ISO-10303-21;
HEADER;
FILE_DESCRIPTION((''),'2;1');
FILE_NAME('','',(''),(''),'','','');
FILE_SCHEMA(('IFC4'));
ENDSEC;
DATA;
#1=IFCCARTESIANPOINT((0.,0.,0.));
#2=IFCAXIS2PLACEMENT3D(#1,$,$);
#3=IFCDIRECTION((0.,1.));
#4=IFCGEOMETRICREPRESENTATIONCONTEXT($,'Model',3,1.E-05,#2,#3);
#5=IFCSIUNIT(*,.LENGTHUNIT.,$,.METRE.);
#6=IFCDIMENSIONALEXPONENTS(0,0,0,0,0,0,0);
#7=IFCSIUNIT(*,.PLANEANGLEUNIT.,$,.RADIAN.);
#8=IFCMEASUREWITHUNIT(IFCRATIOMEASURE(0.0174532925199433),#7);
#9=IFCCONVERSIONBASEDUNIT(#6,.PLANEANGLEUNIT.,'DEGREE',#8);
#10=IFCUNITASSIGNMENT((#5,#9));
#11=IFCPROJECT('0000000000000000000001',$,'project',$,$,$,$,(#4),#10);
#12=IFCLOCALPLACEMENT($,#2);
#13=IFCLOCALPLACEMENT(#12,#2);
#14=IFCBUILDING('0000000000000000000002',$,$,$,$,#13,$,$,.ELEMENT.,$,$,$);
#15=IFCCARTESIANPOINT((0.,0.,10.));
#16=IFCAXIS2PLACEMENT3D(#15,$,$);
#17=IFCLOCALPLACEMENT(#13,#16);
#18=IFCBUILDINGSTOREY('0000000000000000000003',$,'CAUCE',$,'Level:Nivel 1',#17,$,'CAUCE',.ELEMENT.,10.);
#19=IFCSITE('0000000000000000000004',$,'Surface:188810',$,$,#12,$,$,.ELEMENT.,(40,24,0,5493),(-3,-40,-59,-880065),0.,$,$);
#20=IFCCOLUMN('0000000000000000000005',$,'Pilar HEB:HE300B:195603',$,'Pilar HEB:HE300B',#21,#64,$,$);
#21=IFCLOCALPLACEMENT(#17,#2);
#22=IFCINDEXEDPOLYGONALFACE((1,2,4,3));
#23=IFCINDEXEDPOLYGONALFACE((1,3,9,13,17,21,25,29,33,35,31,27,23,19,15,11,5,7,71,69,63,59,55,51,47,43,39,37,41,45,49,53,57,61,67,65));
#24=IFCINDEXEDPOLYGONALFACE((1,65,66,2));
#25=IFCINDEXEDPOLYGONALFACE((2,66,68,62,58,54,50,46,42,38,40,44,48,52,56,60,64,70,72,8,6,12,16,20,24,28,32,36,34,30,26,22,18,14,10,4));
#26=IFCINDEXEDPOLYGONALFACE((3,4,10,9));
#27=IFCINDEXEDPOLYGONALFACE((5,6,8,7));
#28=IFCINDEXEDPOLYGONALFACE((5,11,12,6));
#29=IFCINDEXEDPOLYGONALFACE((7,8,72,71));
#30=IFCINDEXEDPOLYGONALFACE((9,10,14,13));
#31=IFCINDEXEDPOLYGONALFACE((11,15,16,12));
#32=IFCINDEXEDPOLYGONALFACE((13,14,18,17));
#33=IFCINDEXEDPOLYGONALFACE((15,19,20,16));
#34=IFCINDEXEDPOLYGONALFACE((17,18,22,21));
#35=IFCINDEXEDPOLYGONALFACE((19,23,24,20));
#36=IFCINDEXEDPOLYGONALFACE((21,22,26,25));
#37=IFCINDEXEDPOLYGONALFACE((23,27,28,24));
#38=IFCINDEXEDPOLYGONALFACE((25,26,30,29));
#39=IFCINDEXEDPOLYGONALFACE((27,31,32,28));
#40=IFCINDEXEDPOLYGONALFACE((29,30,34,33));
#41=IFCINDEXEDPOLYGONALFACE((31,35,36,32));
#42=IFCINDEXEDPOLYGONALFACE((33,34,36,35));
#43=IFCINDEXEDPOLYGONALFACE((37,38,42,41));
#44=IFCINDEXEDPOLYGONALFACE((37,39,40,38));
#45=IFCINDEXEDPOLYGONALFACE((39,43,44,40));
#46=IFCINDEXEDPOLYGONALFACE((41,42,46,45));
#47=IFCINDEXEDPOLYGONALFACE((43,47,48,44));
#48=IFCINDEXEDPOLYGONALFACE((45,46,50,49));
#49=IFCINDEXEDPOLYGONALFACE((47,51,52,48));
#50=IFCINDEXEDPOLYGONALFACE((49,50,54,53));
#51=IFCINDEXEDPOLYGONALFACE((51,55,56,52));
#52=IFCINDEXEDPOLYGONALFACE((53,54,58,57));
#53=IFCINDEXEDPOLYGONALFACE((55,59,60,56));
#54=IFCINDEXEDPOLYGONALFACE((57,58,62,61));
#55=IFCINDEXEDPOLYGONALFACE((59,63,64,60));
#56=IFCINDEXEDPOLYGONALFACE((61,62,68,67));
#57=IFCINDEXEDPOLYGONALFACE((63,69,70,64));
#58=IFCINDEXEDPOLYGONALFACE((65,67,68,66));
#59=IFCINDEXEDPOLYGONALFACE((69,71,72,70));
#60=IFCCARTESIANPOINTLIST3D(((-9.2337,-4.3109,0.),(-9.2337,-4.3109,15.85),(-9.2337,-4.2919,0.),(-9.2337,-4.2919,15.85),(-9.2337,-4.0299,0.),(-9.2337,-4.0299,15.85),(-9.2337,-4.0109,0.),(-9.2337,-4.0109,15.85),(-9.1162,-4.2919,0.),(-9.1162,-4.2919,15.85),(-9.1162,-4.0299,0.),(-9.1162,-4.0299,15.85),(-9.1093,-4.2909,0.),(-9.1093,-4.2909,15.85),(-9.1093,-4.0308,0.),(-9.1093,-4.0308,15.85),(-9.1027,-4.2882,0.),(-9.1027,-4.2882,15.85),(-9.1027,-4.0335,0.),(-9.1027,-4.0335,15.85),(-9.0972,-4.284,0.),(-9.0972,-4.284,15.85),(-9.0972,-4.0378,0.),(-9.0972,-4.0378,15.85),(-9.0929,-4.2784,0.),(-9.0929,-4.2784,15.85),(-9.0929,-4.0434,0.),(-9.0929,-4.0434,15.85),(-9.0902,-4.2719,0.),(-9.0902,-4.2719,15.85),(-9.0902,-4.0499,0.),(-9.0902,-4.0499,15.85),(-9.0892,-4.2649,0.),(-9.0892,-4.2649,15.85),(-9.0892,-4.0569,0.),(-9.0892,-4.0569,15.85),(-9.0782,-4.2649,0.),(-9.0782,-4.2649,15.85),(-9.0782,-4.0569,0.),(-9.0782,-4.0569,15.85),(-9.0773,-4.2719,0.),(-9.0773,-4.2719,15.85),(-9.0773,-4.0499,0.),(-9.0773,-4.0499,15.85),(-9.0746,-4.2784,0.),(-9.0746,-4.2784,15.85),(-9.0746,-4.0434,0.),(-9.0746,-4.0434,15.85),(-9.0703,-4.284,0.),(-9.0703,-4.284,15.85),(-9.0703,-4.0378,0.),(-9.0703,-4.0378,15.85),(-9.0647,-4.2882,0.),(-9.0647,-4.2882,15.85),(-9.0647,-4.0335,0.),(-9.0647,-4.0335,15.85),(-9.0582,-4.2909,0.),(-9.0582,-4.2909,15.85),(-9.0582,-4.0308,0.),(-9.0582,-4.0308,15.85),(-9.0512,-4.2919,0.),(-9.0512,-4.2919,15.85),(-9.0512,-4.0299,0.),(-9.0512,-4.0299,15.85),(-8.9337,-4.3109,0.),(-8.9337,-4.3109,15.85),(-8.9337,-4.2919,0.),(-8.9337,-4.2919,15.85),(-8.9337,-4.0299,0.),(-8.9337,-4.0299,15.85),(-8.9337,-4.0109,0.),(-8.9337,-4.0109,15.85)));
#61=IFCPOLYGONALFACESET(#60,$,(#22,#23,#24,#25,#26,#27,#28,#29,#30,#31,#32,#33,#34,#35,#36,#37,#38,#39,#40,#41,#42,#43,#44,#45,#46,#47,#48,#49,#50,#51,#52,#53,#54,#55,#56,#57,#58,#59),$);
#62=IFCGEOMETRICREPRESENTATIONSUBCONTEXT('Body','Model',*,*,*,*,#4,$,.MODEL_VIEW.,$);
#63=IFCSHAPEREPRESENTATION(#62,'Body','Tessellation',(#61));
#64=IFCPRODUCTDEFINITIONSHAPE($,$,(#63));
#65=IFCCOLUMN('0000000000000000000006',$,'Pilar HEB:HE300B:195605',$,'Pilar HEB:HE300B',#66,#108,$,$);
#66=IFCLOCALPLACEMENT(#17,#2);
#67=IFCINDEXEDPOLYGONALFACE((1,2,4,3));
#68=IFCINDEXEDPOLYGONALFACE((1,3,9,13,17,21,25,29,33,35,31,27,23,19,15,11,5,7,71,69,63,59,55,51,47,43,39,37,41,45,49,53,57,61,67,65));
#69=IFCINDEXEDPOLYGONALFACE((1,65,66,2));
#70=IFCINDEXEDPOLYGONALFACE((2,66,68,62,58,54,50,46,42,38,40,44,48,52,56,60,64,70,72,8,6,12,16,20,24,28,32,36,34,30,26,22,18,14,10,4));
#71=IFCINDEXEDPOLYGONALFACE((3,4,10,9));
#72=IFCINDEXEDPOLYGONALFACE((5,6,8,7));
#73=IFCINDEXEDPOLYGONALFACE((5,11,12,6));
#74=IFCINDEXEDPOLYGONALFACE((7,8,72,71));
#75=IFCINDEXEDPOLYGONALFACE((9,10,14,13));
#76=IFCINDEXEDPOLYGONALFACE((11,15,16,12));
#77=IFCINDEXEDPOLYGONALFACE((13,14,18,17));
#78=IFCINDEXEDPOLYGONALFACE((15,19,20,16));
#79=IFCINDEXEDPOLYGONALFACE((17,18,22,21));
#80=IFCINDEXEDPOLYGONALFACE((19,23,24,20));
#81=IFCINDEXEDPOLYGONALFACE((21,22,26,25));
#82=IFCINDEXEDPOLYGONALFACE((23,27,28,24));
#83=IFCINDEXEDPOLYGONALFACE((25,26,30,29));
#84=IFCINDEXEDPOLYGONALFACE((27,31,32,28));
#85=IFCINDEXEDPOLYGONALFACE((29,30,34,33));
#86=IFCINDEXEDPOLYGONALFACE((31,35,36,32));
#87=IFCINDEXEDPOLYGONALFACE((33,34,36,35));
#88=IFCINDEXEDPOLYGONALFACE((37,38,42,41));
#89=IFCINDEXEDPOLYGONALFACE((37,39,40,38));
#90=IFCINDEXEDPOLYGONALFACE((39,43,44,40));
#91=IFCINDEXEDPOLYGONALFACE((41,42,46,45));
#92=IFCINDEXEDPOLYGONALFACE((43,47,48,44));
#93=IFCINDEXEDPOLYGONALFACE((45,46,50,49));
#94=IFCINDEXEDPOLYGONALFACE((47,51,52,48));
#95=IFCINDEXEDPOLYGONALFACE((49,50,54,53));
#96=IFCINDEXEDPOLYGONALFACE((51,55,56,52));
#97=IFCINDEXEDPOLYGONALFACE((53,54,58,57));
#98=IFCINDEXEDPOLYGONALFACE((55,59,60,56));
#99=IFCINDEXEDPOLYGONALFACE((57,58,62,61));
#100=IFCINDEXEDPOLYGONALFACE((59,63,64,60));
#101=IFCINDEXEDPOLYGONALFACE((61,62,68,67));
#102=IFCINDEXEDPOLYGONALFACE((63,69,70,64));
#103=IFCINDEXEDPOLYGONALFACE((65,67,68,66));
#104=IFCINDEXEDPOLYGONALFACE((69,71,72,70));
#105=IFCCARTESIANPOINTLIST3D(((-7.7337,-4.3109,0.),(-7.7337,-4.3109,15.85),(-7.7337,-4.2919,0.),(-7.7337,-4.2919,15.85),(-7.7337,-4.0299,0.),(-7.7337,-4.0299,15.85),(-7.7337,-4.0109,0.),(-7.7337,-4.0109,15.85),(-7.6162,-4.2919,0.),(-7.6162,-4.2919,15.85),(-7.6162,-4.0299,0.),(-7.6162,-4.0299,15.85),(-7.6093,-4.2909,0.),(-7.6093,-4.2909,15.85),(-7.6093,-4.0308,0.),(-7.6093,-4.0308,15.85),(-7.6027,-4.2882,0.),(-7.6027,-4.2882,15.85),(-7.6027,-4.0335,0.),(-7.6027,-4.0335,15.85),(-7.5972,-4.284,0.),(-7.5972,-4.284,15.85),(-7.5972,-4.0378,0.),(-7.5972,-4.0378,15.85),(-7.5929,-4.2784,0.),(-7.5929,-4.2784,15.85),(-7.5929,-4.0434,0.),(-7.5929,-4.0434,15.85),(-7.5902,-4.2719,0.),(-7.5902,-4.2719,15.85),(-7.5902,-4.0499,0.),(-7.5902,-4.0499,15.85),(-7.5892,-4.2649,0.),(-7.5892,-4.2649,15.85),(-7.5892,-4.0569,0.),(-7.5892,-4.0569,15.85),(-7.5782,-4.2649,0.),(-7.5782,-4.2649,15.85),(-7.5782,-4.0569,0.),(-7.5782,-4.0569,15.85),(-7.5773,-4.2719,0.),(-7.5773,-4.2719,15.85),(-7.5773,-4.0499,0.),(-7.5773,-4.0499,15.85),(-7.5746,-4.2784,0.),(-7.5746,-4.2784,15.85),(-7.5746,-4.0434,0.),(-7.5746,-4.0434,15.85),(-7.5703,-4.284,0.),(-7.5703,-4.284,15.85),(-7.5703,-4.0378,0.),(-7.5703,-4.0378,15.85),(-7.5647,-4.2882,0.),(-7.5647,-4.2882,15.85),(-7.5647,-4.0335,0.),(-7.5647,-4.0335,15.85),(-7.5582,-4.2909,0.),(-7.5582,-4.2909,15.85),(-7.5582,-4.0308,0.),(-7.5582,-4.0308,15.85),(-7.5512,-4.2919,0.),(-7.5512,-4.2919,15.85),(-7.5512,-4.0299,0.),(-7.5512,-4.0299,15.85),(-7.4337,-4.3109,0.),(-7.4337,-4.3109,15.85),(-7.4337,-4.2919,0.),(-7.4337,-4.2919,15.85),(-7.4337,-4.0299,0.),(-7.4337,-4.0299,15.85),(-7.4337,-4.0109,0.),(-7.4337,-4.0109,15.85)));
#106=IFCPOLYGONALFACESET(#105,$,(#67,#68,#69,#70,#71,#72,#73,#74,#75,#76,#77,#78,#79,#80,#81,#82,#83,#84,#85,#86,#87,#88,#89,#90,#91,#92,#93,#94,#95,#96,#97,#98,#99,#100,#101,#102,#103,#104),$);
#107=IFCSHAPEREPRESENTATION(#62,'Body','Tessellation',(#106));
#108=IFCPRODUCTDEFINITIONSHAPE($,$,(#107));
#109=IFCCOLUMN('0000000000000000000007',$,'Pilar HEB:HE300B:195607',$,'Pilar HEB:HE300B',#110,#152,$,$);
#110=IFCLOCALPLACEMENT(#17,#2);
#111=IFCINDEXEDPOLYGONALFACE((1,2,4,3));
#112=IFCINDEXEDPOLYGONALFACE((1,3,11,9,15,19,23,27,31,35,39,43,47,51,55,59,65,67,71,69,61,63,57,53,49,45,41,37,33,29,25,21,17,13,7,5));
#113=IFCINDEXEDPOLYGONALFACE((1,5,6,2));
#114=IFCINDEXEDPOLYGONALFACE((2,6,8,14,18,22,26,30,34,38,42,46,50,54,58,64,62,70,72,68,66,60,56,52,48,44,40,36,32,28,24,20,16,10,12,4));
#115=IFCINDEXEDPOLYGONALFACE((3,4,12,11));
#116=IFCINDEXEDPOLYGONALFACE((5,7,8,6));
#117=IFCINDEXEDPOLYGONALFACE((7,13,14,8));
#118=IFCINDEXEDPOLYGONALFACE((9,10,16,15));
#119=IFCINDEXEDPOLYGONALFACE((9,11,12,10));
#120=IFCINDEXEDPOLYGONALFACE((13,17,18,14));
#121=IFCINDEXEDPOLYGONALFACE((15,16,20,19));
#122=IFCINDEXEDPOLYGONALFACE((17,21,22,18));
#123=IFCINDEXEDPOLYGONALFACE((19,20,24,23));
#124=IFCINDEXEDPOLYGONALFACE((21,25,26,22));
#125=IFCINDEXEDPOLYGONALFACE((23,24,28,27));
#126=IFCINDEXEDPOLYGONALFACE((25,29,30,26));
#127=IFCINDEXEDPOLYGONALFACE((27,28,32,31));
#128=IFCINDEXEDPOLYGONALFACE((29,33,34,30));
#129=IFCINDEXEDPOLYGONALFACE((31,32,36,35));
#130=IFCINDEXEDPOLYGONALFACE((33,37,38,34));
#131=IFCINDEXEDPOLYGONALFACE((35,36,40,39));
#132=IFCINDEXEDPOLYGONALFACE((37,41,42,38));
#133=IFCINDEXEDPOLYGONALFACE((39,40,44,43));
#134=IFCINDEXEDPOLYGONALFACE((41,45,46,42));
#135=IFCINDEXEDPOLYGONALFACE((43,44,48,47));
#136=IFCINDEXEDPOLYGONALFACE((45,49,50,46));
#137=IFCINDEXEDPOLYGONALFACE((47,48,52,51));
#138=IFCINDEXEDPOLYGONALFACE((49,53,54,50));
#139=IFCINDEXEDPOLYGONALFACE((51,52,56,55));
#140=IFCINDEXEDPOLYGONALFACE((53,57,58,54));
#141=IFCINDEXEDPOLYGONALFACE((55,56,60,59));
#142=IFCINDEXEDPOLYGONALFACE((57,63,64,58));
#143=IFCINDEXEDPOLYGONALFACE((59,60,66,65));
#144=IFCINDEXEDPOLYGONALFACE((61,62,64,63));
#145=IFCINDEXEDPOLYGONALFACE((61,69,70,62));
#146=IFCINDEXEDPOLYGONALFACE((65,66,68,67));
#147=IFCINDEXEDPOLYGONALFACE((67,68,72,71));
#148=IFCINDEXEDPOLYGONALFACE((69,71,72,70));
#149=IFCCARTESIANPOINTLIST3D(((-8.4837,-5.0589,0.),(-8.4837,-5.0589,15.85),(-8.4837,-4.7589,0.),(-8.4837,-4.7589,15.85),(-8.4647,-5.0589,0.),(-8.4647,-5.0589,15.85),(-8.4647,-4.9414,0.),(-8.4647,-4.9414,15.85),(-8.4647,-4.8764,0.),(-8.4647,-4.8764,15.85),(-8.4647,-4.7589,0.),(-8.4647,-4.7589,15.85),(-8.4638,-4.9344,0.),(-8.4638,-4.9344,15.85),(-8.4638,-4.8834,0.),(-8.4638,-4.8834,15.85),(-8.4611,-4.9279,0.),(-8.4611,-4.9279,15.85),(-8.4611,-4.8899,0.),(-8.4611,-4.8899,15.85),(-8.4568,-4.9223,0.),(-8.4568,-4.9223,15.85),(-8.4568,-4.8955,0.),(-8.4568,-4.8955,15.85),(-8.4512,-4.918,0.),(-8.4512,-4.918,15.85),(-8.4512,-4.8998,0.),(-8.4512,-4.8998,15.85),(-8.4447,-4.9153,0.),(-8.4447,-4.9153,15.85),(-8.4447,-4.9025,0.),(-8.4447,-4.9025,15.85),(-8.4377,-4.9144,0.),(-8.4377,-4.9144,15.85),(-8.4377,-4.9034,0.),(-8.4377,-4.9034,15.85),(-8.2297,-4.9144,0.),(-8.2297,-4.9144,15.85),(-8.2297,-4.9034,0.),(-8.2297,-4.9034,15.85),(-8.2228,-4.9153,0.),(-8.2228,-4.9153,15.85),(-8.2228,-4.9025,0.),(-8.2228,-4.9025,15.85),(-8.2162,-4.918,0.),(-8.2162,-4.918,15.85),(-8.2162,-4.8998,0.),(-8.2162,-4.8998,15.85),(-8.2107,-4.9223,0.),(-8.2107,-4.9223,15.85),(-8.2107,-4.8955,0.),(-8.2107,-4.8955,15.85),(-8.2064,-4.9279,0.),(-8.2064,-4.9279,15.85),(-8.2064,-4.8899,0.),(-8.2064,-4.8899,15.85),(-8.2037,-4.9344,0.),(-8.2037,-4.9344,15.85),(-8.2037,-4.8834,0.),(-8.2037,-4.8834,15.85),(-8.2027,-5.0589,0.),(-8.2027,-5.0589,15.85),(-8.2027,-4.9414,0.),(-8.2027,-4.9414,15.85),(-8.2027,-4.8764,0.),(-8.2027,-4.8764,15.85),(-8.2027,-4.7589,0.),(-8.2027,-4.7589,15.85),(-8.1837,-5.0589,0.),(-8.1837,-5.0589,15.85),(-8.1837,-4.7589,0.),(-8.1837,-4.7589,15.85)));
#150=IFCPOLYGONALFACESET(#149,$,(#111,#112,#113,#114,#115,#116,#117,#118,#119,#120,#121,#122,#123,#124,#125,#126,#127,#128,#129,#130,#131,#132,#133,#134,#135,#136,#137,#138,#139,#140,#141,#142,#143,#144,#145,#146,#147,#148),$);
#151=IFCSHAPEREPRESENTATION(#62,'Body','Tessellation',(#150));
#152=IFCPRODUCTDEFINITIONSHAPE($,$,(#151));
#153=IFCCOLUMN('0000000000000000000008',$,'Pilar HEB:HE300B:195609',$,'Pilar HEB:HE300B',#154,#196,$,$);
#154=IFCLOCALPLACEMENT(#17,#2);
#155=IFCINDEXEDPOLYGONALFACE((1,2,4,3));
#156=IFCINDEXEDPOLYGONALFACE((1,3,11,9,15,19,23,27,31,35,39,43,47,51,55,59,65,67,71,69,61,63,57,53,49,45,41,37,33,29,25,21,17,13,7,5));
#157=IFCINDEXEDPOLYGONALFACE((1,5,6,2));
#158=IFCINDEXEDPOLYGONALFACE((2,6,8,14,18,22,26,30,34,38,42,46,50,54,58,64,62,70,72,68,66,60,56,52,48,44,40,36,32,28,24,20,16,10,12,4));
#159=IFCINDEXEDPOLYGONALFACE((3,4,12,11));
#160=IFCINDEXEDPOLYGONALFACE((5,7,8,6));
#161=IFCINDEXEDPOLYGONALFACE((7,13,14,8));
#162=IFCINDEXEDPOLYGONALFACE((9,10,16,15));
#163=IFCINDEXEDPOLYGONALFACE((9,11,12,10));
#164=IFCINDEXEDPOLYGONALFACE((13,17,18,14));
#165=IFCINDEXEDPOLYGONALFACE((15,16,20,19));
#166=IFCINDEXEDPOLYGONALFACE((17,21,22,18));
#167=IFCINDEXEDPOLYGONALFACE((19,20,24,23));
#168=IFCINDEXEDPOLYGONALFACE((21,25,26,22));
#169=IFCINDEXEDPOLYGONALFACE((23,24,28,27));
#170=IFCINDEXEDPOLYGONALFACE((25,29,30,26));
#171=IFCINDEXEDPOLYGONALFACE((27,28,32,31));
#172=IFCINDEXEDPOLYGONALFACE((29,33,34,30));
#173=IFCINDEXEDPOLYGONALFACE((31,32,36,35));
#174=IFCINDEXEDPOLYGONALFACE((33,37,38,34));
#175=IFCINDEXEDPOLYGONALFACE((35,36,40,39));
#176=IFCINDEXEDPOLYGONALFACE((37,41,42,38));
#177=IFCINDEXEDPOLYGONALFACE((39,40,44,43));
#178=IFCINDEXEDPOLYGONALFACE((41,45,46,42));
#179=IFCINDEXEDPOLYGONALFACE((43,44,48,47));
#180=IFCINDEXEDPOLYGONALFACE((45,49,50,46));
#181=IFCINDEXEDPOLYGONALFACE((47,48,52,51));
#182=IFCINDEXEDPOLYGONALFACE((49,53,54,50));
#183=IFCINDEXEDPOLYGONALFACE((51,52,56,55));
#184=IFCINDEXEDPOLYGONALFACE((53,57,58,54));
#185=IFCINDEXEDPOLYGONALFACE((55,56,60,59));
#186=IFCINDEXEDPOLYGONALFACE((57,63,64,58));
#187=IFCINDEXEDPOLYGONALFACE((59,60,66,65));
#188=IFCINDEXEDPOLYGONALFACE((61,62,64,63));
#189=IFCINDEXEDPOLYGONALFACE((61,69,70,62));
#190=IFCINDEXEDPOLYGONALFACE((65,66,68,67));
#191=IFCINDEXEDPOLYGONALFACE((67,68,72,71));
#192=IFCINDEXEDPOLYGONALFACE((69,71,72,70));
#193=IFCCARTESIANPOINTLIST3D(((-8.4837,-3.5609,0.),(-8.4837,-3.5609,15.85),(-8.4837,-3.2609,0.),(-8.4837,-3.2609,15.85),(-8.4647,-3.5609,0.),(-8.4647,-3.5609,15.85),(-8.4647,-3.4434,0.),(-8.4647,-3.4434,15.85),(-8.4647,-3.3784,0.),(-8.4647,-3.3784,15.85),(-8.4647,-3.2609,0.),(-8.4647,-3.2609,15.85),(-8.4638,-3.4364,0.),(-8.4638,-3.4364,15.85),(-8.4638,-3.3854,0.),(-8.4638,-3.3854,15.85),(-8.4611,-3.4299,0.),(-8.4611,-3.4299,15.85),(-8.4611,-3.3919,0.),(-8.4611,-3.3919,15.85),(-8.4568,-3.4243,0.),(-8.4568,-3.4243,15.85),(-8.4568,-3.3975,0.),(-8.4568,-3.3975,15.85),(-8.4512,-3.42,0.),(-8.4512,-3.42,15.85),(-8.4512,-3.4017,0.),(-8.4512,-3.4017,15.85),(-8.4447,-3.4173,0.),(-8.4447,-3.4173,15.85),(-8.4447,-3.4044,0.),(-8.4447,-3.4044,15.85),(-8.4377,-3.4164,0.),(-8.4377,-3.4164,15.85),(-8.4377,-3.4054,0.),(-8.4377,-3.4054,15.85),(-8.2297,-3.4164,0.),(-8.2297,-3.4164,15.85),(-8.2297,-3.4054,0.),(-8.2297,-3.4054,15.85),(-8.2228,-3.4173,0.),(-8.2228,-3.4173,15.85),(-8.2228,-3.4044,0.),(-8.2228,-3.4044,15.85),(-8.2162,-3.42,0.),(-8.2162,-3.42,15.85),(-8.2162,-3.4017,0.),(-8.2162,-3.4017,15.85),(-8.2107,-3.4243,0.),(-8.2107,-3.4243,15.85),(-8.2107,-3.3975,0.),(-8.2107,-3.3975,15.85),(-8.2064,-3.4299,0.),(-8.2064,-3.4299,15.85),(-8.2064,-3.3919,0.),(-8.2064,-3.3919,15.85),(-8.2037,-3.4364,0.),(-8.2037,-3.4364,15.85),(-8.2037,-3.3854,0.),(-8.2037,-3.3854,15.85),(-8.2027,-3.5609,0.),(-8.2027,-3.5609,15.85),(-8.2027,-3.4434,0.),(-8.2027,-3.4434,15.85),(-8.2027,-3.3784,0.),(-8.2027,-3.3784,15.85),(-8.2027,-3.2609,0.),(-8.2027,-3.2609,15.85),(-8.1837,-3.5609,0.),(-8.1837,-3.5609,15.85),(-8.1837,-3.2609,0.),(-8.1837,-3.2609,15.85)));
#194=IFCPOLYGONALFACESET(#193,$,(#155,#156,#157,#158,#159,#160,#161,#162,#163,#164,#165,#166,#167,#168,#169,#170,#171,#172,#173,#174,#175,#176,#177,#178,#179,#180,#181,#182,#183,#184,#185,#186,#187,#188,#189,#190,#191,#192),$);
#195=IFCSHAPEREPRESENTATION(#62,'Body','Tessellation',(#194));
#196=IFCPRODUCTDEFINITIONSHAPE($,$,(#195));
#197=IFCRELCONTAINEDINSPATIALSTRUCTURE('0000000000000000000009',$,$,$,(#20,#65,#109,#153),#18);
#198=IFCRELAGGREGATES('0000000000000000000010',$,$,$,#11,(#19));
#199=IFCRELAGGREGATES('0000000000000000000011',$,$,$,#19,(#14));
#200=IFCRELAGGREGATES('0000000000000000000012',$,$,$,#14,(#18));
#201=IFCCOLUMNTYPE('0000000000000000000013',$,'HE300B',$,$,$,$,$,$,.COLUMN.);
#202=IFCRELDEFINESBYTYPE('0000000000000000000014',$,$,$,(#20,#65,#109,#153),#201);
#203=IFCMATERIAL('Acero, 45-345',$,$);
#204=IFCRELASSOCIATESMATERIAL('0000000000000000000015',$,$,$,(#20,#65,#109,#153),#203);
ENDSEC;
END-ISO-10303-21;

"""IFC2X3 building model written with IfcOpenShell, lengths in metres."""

from ifc_helpers import new_model, entity, si_unit, converted_unit, direction, frame, frame_2d, origin, place, context, subcontext, project, spatial, polyline, circle_curve, parameter, trimmed, segment, composite_curve, outline, extrude, source, transform, mapped, material, type_object, type_shapes, element, save


model = new_model("IFC2X3")

# Units and contexts
model_context = context("Model", 3, precision=1e-05, world=origin(), true_north=direction((0.0, 1.0)))
body_context = subcontext(model_context, "Body", "Model", "MODEL_VIEW")
ifc_project = project(units=[si_unit("LENGTHUNIT", "METRE"), converted_unit("PLANEANGLEUNIT", "DEGREE", entity("IfcRatioMeasure", 0.0174532925199433), si_unit("PLANEANGLEUNIT", "RADIAN"), dimensions=[0, 0, 0, 0, 0, 0, 0])], contexts=[model_context])

# Site, building, storey
site_placement = place(None, origin())
site = spatial("IfcSite", under=ifc_project, at=site_placement, Name="Surface:188810", CompositionType="ELEMENT", RefLatitude=(40, 24, 0, 5493), RefLongitude=(-3, -40, -59, -880065), RefElevation=0.0)
building_placement = place(site_placement, origin())
building = spatial("IfcBuilding", under=site, at=building_placement, CompositionType="ELEMENT")
storey_placement = place(building_placement, frame((0.0, 0.0, 10.0)))
storey = spatial("IfcBuildingStorey", under=building, at=storey_placement, Name="CAUCE", ObjectType="Level:Nivel 1", LongName="CAUCE", CompositionType="ELEMENT", Elevation=10.0)

# Columns
ifc_material_1 = material(Name="Acero, 45-345")
column_type_1 = type_object("IfcColumnType", Name="HE300B", PredefinedType="COLUMN")
shared_shape_1 = source(origin(), body_context, "Body", "SweptSolid", [
    extrude(outline(composite_curve([segment(polyline([(0.131, -0.15), (0.15, -0.15)]), True, "CONTINUOUS"), segment(polyline([(0.15, -0.15), (0.15, 0.15)]), True, "CONTINUOUS"), segment(polyline([(0.15, 0.15), (0.131, 0.15)]), True, "CONTINUOUS"), segment(polyline([(0.131, 0.15), (0.131, 0.0325)]), True, "CONTINUOUS"), segment(trimmed(circle_curve(frame_2d((0.104, 0.0325), x_axis=(1.0, 0.0)), 0.027), [parameter(270.0)], [parameter(0.0)], True, "PARAMETER"), False, "CONTINUOUS"), segment(polyline([(0.104, 0.0055), (-0.104, 0.0055)]), True, "CONTINUOUS"), segment(trimmed(circle_curve(frame_2d((-0.104, 0.0325), x_axis=(0.0, -1.0)), 0.027), [parameter(270.0)], [parameter(0.0)], True, "PARAMETER"), False, "CONTINUOUS"), segment(polyline([(-0.131, 0.0325), (-0.131, 0.15)]), True, "CONTINUOUS"), segment(polyline([(-0.131, 0.15), (-0.15, 0.15)]), True, "CONTINUOUS"), segment(polyline([(-0.15, 0.15), (-0.15, -0.15)]), True, "CONTINUOUS"), segment(polyline([(-0.15, -0.15), (-0.131, -0.15)]), True, "CONTINUOUS"), segment(polyline([(-0.131, -0.15), (-0.131, -0.0325)]), True, "CONTINUOUS"), segment(trimmed(circle_curve(frame_2d((-0.104, -0.0325), x_axis=(-1.0, 0.0)), 0.027), [parameter(270.0)], [parameter(0.0)], True, "PARAMETER"), False, "CONTINUOUS"), segment(polyline([(-0.104, -0.0055), (0.104, -0.0055)]), True, "CONTINUOUS"), segment(trimmed(circle_curve(frame_2d((0.104, -0.0325), x_axis=(0.0, 1.0)), 0.027), [parameter(270.0)], [parameter(0.0)], True, "PARAMETER"), False, "CONTINUOUS"), segment(polyline([(0.131, -0.0325), (0.131, -0.15)]), True, "CONTINUOUS")], self_intersect=False)), frame((0.0, 0.0, 10.0), z_axis=(0.0, 0.0, 1.0), x_axis=(0.0, -1.0, 0.0)), (0.0, 0.0, 1.0), 15.85),
])
type_shapes(column_type_1, [shared_shape_1])
for number, where, name in (
    (1, (-9.0837, -4.1609, -10.0), "Pilar HEB:HE300B:195603"),
    (2, (-7.5837, -4.1609, -10.0), "Pilar HEB:HE300B:195605"),
):
    element("IfcColumn", number, at=place(storey_placement, frame(where)), inside=storey, type_object=column_type_1, material=ifc_material_1, Name=name, ObjectType="Pilar HEB:HE300B", context=body_context, shape_type="MappedRepresentation", body=[
        mapped(shared_shape_1, transform((0.0, 0.0, 0.0), scale=1.0)),
    ])
for number, where, z_axis, x_axis, name in (
    (3, (-8.3337, -4.9089, -10.0), (0.0, 0.0, 1.0), (0.0, -1.0, 0.0), "Pilar HEB:HE300B:195607"),
    (4, (-8.3337, -3.4109, -10.0), (0.0, 0.0, 1.0), (0.0, -1.0, 0.0), "Pilar HEB:HE300B:195609"),
):
    element("IfcColumn", number, at=place(storey_placement, frame(where, z_axis=z_axis, x_axis=x_axis)), inside=storey, type_object=column_type_1, material=ifc_material_1, Name=name, ObjectType="Pilar HEB:HE300B", context=body_context, shape_type="MappedRepresentation", body=[
        mapped(shared_shape_1, transform((0.0, 0.0, 0.0), scale=1.0)),
    ])

save(model, "model.ifc")
